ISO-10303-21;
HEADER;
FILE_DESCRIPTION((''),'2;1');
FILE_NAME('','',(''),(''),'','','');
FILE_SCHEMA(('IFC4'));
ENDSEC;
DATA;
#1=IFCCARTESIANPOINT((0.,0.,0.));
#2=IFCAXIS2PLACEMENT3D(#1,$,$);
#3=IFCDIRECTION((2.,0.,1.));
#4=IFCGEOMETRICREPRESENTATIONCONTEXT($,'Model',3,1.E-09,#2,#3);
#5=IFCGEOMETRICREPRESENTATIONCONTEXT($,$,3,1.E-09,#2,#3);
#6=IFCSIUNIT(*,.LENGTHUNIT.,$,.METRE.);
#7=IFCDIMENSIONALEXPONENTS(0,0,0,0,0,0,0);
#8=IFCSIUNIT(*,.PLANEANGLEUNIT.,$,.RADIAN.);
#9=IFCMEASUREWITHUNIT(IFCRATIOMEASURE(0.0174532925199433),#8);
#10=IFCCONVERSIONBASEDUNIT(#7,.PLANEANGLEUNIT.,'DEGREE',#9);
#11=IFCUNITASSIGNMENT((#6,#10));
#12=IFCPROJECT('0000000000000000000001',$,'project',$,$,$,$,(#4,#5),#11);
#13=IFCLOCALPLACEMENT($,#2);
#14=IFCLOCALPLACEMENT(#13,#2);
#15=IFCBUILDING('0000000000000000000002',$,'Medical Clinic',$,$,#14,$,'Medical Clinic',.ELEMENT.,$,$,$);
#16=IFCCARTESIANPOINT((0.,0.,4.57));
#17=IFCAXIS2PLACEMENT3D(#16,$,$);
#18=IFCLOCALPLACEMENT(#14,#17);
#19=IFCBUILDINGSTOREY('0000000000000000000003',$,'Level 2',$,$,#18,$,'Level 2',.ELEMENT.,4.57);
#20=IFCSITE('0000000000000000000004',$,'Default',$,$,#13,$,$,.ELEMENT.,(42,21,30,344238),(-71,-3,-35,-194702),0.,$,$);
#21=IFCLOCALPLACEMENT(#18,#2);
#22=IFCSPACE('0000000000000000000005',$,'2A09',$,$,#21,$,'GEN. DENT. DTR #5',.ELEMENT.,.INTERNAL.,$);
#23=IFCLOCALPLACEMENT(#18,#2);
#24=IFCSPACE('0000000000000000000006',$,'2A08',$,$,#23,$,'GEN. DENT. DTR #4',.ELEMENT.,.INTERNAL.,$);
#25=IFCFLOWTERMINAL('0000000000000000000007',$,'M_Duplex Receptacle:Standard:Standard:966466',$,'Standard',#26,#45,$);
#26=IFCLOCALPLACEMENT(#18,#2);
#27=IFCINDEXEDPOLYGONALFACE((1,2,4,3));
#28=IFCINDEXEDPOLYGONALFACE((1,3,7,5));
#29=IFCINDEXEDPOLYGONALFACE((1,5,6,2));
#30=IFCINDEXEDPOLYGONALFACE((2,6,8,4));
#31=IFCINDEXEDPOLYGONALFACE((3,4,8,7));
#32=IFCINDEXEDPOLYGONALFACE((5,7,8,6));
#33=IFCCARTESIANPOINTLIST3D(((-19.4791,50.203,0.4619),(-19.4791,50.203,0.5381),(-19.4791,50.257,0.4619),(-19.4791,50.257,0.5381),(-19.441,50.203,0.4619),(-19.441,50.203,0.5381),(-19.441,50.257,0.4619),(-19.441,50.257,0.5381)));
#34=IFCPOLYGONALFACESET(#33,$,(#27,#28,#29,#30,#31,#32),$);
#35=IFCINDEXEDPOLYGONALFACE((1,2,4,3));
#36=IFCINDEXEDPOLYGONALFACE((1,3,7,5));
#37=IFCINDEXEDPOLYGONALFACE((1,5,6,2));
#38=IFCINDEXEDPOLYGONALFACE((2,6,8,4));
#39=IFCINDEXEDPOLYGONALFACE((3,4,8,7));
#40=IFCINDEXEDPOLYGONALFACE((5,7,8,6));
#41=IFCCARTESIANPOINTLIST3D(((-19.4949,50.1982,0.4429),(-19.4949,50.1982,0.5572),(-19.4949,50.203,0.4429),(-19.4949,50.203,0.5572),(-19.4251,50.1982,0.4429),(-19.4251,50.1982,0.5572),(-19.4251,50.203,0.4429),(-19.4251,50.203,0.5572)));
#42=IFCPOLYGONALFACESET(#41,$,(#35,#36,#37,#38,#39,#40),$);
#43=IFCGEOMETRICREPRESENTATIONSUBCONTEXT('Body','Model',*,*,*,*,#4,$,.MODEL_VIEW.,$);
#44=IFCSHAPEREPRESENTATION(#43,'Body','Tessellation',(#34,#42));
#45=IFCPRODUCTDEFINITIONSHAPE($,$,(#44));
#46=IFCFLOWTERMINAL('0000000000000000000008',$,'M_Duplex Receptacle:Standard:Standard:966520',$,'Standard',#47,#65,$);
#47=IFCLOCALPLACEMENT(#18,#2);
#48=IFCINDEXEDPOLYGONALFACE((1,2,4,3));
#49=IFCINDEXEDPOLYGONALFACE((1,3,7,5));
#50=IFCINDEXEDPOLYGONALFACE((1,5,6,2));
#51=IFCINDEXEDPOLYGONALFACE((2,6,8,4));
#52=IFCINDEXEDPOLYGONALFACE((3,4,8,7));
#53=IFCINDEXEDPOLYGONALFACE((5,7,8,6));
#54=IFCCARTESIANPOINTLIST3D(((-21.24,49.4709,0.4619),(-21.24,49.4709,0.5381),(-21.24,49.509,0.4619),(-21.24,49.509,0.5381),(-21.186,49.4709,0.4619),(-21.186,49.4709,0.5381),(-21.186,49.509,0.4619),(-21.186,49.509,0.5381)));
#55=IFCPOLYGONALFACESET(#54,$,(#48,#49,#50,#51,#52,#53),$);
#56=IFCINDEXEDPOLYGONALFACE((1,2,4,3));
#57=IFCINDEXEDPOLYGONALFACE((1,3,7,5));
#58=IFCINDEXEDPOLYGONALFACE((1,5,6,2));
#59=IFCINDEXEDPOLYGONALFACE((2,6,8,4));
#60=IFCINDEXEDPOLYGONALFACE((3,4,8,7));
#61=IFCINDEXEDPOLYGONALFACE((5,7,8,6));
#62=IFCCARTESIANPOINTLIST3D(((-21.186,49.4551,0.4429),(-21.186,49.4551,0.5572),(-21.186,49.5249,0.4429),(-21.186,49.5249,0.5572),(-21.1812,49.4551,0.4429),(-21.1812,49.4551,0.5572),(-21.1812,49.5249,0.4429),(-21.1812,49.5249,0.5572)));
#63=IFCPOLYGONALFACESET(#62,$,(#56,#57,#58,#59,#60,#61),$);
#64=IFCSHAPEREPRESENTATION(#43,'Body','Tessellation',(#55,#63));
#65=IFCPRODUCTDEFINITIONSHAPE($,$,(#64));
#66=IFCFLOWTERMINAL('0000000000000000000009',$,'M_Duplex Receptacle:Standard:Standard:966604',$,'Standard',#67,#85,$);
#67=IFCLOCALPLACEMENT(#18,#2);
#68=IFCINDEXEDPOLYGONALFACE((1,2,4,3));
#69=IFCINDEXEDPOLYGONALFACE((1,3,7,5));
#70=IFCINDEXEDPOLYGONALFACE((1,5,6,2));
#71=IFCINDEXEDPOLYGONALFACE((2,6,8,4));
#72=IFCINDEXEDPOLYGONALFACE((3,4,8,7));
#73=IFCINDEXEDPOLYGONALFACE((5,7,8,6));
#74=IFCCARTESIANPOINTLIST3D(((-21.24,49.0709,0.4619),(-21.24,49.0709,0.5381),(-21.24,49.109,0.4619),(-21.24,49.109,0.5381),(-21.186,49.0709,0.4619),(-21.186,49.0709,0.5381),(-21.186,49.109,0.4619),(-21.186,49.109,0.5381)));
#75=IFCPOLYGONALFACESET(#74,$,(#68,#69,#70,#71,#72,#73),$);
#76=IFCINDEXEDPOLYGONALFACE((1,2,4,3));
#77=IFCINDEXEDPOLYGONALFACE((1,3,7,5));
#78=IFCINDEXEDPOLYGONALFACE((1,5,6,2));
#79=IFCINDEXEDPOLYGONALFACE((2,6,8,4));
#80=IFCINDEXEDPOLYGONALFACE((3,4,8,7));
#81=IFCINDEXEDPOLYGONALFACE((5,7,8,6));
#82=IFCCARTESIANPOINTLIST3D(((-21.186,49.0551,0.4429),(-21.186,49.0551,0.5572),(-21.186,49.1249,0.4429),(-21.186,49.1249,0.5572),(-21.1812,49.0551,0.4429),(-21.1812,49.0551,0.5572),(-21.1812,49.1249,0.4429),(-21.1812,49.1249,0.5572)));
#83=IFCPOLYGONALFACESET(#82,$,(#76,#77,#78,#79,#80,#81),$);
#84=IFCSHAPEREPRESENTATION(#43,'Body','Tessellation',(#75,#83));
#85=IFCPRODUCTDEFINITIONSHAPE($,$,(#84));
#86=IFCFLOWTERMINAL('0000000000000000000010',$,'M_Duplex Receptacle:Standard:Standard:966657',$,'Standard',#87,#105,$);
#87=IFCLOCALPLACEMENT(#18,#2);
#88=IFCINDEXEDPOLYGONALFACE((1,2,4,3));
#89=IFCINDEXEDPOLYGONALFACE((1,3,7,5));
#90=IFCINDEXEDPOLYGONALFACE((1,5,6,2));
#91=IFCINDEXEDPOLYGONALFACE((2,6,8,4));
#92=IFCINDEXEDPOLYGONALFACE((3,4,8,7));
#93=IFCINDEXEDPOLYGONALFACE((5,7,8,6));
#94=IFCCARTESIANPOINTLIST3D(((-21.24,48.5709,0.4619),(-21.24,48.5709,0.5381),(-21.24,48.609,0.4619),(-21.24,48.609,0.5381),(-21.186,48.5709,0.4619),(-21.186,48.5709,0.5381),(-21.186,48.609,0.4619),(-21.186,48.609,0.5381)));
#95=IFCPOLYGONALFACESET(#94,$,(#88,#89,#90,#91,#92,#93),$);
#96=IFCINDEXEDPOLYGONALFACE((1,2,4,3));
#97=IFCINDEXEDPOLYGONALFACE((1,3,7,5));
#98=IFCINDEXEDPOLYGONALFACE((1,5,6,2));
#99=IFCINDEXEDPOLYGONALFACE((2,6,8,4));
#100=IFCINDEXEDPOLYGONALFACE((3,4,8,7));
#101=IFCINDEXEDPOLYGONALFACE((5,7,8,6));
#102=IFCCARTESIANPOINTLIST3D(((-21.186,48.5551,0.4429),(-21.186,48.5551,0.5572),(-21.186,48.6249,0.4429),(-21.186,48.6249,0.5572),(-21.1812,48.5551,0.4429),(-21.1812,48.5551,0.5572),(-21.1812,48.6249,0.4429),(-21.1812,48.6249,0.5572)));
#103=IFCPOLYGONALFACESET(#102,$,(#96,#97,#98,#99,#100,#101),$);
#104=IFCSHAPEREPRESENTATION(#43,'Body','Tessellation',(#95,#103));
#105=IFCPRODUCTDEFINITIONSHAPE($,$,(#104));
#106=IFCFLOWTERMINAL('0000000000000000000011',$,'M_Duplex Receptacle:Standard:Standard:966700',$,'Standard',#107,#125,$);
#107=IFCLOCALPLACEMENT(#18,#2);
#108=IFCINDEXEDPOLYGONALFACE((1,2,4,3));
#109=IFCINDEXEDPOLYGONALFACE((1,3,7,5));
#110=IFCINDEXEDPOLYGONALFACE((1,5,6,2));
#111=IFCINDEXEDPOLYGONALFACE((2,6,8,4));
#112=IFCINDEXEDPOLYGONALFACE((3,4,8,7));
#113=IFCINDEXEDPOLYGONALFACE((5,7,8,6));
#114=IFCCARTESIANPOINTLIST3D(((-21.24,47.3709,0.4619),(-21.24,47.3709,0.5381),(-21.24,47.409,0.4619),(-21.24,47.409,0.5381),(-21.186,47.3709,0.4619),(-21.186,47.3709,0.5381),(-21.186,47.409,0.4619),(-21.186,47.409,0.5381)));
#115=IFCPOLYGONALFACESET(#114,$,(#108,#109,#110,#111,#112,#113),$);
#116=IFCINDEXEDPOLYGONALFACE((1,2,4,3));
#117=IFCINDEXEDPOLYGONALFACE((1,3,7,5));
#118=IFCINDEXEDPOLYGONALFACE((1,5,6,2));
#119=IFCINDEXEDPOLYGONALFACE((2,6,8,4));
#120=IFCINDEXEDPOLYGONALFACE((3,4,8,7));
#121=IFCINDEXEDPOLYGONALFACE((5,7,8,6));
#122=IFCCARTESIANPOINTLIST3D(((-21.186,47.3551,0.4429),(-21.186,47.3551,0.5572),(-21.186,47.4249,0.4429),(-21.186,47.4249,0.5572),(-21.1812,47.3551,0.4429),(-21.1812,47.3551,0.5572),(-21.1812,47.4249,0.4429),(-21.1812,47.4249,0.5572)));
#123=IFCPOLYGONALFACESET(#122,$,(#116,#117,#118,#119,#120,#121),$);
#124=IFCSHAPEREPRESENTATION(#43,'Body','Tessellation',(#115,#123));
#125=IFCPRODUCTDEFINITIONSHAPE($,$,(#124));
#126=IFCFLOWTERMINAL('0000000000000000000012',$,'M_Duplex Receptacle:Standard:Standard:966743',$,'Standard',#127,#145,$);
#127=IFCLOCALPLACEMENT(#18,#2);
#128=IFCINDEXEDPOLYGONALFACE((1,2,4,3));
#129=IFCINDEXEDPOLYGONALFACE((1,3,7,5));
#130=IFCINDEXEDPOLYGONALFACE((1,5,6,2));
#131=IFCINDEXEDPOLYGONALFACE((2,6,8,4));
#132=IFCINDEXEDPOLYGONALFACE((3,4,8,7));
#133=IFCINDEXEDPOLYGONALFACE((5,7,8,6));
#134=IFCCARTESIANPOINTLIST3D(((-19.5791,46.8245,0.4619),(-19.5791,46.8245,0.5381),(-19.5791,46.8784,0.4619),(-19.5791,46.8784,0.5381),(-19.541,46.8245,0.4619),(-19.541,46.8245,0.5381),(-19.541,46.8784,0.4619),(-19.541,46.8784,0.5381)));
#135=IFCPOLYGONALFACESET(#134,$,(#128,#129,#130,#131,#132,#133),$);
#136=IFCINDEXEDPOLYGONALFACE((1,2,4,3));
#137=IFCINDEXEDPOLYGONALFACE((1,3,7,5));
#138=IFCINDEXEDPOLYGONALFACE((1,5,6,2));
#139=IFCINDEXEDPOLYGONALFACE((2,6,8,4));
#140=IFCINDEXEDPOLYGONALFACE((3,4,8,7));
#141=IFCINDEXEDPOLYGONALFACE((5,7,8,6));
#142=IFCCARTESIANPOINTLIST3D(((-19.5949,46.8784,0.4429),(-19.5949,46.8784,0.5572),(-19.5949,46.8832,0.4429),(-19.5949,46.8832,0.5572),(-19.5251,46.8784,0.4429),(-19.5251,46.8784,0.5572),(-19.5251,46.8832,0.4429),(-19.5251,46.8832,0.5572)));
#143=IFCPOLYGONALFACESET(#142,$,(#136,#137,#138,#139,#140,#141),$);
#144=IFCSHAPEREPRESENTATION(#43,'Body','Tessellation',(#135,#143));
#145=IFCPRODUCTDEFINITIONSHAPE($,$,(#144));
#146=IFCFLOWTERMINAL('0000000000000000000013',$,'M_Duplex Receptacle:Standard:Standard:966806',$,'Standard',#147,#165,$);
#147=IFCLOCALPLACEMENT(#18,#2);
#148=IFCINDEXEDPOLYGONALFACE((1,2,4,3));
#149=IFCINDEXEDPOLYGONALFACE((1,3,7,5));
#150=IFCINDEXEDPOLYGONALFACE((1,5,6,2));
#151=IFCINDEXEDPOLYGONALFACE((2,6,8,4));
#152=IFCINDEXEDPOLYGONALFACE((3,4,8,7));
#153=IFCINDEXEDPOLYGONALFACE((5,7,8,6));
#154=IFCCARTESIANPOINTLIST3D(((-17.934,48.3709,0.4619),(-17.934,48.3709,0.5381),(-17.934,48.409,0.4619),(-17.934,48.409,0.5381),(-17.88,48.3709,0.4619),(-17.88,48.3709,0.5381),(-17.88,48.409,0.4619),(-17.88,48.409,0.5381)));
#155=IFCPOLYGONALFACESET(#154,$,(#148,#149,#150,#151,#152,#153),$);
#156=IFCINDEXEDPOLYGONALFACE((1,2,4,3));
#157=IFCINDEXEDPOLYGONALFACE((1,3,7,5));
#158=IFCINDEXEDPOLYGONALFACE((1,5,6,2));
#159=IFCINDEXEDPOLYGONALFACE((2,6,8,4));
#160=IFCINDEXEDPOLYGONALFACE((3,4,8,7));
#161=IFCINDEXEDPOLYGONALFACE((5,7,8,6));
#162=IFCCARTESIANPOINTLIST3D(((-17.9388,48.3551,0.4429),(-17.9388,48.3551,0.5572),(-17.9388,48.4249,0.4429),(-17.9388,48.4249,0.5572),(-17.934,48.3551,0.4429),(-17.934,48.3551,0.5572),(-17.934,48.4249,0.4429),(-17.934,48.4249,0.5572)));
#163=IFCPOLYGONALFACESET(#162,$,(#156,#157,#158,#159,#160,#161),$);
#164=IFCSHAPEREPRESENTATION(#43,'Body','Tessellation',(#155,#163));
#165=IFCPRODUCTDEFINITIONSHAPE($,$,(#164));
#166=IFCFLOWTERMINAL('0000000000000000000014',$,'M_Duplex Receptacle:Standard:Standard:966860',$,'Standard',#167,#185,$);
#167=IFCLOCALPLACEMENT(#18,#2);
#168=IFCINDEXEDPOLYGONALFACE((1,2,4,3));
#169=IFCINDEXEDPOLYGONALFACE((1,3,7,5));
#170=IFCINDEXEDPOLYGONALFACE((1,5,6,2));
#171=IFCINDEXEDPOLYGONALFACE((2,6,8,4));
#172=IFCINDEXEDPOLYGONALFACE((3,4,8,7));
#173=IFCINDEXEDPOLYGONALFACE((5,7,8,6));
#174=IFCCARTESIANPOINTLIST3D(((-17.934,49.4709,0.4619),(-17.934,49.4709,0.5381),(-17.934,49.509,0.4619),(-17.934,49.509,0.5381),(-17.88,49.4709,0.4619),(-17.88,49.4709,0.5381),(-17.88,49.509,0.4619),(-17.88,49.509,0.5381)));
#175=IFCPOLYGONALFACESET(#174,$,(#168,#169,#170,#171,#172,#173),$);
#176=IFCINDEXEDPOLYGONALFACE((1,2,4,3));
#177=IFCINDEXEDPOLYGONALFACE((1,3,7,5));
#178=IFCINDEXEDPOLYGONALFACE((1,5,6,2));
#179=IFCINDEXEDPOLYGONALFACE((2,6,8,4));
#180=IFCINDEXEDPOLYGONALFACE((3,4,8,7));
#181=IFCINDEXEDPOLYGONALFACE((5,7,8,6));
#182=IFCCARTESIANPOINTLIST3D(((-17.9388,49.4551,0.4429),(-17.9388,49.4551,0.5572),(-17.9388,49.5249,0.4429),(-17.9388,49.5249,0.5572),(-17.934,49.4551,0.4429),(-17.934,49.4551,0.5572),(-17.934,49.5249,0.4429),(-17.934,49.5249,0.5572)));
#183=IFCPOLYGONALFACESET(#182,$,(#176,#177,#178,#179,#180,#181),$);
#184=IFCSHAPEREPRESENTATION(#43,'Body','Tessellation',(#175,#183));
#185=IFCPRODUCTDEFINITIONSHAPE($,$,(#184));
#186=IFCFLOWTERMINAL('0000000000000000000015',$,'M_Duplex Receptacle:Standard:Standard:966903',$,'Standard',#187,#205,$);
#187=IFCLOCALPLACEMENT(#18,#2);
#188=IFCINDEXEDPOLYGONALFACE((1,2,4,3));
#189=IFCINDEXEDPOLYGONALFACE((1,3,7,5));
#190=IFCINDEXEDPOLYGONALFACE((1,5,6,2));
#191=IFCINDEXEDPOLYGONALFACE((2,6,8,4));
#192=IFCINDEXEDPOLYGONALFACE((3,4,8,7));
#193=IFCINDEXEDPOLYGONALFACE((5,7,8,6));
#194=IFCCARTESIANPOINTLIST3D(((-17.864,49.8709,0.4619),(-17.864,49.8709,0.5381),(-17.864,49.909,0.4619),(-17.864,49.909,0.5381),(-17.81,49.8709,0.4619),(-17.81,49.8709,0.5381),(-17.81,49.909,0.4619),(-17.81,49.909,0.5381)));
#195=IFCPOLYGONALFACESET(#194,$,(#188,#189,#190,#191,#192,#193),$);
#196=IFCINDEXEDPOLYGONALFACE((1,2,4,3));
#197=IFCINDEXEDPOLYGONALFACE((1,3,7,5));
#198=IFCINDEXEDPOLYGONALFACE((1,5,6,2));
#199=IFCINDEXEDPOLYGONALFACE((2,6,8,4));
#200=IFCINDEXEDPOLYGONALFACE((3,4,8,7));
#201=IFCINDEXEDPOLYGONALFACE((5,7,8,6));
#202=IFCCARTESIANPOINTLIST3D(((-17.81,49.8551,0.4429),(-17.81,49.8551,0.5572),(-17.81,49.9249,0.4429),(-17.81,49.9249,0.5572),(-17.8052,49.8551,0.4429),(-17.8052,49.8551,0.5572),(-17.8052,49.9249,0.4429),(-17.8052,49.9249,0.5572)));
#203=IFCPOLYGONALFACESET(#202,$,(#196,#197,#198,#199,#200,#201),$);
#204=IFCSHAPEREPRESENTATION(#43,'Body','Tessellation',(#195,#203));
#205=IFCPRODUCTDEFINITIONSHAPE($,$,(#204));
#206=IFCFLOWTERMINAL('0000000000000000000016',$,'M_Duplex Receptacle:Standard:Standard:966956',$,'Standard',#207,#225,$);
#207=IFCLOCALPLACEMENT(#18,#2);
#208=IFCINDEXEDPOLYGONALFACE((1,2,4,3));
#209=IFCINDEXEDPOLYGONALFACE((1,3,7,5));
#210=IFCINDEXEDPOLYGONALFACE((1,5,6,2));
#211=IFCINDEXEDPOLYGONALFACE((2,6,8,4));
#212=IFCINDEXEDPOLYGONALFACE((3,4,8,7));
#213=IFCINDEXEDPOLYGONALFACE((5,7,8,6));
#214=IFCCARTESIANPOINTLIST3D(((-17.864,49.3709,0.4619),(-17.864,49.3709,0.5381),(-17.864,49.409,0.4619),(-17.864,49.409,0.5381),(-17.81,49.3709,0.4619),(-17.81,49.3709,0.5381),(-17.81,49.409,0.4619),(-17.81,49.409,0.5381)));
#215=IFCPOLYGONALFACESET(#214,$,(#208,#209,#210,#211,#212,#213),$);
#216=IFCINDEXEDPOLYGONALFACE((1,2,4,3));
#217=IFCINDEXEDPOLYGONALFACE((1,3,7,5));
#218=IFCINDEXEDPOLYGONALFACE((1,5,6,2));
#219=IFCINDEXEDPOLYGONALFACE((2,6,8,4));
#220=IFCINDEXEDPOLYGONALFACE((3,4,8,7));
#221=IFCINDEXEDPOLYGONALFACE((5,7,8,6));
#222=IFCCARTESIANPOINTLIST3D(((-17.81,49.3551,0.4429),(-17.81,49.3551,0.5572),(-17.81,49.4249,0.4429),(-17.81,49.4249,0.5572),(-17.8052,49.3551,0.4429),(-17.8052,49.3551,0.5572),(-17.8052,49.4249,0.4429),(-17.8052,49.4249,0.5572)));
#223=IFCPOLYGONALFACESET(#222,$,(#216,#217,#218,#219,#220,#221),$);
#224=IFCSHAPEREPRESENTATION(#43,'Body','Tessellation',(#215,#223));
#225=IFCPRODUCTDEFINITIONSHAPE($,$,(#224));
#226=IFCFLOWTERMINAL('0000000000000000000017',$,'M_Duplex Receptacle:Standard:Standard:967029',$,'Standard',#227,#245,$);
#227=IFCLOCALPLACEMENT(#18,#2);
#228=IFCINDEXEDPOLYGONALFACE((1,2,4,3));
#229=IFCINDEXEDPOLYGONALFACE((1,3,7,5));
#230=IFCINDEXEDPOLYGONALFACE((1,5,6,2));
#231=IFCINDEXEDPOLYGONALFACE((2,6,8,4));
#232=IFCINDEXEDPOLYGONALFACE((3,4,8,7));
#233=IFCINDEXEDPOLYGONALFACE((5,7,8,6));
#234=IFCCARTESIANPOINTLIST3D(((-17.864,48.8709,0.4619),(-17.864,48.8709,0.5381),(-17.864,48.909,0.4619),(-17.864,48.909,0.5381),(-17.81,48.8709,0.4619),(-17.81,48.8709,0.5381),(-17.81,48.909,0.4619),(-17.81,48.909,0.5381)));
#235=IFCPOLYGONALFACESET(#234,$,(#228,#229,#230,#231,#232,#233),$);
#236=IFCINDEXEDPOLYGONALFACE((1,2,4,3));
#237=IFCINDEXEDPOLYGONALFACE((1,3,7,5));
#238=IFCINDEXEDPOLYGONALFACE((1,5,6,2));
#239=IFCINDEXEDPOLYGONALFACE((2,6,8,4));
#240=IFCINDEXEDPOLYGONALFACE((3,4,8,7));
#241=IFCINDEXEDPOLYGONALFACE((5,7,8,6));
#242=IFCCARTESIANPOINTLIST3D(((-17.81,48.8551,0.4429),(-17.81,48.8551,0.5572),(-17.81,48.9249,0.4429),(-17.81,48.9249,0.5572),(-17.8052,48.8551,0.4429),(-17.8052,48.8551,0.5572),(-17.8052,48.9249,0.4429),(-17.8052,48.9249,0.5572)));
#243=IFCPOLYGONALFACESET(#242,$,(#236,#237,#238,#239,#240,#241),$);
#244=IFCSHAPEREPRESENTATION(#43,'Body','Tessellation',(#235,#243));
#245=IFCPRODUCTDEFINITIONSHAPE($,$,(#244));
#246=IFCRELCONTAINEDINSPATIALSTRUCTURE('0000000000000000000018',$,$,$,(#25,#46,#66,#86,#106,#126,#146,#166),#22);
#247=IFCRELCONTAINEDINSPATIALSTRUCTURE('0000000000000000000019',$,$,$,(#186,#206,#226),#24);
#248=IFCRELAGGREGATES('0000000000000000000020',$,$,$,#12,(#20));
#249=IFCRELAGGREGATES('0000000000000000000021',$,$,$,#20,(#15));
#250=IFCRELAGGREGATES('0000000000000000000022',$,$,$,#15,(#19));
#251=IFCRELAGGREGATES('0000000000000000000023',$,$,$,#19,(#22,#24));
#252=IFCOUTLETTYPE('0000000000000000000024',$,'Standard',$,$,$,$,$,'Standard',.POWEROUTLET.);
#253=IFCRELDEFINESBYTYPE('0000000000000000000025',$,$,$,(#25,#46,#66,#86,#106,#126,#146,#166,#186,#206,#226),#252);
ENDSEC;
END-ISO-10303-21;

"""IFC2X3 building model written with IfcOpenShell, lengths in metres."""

from ifc_helpers import new_model, entity, si_unit, converted_unit, direction, frame, frame_2d, origin, origin_2d_with_axis, place, context, subcontext, project, spatial, rectangle, extrude, source, transform, mapped, type_object, type_shapes, element, save


model = new_model("IFC2X3")

# Units and contexts
model_context = context("Model", 3, precision=1e-09, world=origin(), true_north=direction((2.0, 0.0, 1.0)))
context_of_model = context(None, 3, precision=1e-09, world=origin(), true_north=direction((2.0, 0.0, 1.0)))
body_context = subcontext(model_context, "Body", "Model", "MODEL_VIEW")
ifc_project = project(units=[si_unit("LENGTHUNIT", "METRE"), converted_unit("PLANEANGLEUNIT", "DEGREE", entity("IfcRatioMeasure", 0.0174532925199433), si_unit("PLANEANGLEUNIT", "RADIAN"), dimensions=[0, 0, 0, 0, 0, 0, 0])], contexts=[model_context, context_of_model])

# Site, building, storey, space
site_placement = place(None, origin())
site = spatial("IfcSite", under=ifc_project, at=site_placement, Name="Default", CompositionType="ELEMENT", RefLatitude=(42, 21, 30, 344238), RefLongitude=(-71, -3, -35, -194702), RefElevation=0.0)
building_placement = place(site_placement, origin())
building = spatial("IfcBuilding", under=site, at=building_placement, Name="Medical Clinic", LongName="Medical Clinic", CompositionType="ELEMENT")
storey_placement = place(building_placement, frame((0.0, 0.0, 4.57)))
storey = spatial("IfcBuildingStorey", under=building, at=storey_placement, Name="Level 2", LongName="Level 2", CompositionType="ELEMENT", Elevation=4.57)
space_1_placement = place(storey_placement, origin())
space_1 = spatial("IfcSpace", under=storey, at=space_1_placement, Name="2A09", LongName="GEN. DENT. DTR #5", CompositionType="ELEMENT", InteriorOrExteriorSpace="INTERNAL")

# Flow terminals
outlet_type = type_object("IfcOutletType", Name="Standard", ElementType="Standard", PredefinedType="POWEROUTLET")
shared_shape_1 = source(origin(), body_context, "Body", "SweptSolid", [
    extrude(rectangle(XDim=0.0381, YDim=0.0762, at=origin_2d_with_axis()), frame((0.0, 0.0, -0.054), z_axis=(0.0, 0.0, 1.0), x_axis=(-1.0, 0.0, 0.0)), (0.0, 0.0, 1.0), 0.054),
    extrude(rectangle(XDim=0.0698, YDim=0.1143, at=frame_2d((0.0, 0.0), x_axis=(1.0, 0.0))), frame((0.0, 0.0, 0.0), z_axis=(0.0, 0.0, 1.0), x_axis=(-1.0, 0.0, 0.0)), (0.0, 0.0, 1.0), 0.0048),
])
type_shapes(outlet_type, [shared_shape_1])
for number, where, z_axis, x_axis, name in (
    (1, (-19.46, 50.203, 0.5), (0.0, -1.0, 0.0), (1.0, 0.0, 0.0), "M_Duplex Receptacle:Standard:Standard:966466"),
    (2, (-21.186, 49.49, 0.5), (1.0, 0.0, 0.0), (0.0, 1.0, 0.0), "M_Duplex Receptacle:Standard:Standard:966520"),
    (3, (-21.186, 49.09, 0.5), (1.0, 0.0, 0.0), (0.0, 1.0, 0.0), "M_Duplex Receptacle:Standard:Standard:966604"),
    (4, (-21.186, 48.59, 0.5), (1.0, 0.0, 0.0), (0.0, 1.0, 0.0), "M_Duplex Receptacle:Standard:Standard:966657"),
    (5, (-21.186, 47.39, 0.5), (1.0, 0.0, 0.0), (0.0, 1.0, 0.0), "M_Duplex Receptacle:Standard:Standard:966700"),
    (6, (-19.56, 46.8784, 0.5), (0.0, 1.0, 0.0), (-1.0, 0.0, 0.0), "M_Duplex Receptacle:Standard:Standard:966743"),
    (7, (-17.934, 48.39, 0.5), (-1.0, 0.0, 0.0), (0.0, -1.0, 0.0), "M_Duplex Receptacle:Standard:Standard:966806"),
    (8, (-17.934, 49.49, 0.5), (-1.0, 0.0, 0.0), (0.0, -1.0, 0.0), "M_Duplex Receptacle:Standard:Standard:966860"),
):
    element("IfcFlowTerminal", number, at=place(space_1_placement, frame(where, z_axis=z_axis, x_axis=x_axis)), inside=space_1, type_object=outlet_type, Name=name, ObjectType="Standard", context=body_context, shape_type="MappedRepresentation", body=[
        mapped(shared_shape_1, transform((0.0, 0.0, 0.0), scale=1.0)),
    ])

# Shared definitions
space_2_placement = place(storey_placement, origin())
space_2 = spatial("IfcSpace", under=storey, at=space_2_placement, Name="2A08", LongName="GEN. DENT. DTR #4", CompositionType="ELEMENT", InteriorOrExteriorSpace="INTERNAL")

# Flow terminals
for number, where, z_axis, x_axis, name in (
    (9, (-17.81, 49.89, 0.5), (1.0, 0.0, 0.0), (0.0, 1.0, 0.0), "M_Duplex Receptacle:Standard:Standard:966903"),
    (10, (-17.81, 49.39, 0.5), (1.0, 0.0, 0.0), (0.0, 1.0, 0.0), "M_Duplex Receptacle:Standard:Standard:966956"),
    (11, (-17.81, 48.89, 0.5), (1.0, 0.0, 0.0), (0.0, 1.0, 0.0), "M_Duplex Receptacle:Standard:Standard:967029"),
):
    element("IfcFlowTerminal", number, at=place(space_2_placement, frame(where, z_axis=z_axis, x_axis=x_axis)), inside=space_2, type_object=outlet_type, Name=name, ObjectType="Standard", context=body_context, shape_type="MappedRepresentation", body=[
        mapped(shared_shape_1, transform((0.0, 0.0, 0.0), scale=1.0)),
    ])

save(model, "model.ifc")
